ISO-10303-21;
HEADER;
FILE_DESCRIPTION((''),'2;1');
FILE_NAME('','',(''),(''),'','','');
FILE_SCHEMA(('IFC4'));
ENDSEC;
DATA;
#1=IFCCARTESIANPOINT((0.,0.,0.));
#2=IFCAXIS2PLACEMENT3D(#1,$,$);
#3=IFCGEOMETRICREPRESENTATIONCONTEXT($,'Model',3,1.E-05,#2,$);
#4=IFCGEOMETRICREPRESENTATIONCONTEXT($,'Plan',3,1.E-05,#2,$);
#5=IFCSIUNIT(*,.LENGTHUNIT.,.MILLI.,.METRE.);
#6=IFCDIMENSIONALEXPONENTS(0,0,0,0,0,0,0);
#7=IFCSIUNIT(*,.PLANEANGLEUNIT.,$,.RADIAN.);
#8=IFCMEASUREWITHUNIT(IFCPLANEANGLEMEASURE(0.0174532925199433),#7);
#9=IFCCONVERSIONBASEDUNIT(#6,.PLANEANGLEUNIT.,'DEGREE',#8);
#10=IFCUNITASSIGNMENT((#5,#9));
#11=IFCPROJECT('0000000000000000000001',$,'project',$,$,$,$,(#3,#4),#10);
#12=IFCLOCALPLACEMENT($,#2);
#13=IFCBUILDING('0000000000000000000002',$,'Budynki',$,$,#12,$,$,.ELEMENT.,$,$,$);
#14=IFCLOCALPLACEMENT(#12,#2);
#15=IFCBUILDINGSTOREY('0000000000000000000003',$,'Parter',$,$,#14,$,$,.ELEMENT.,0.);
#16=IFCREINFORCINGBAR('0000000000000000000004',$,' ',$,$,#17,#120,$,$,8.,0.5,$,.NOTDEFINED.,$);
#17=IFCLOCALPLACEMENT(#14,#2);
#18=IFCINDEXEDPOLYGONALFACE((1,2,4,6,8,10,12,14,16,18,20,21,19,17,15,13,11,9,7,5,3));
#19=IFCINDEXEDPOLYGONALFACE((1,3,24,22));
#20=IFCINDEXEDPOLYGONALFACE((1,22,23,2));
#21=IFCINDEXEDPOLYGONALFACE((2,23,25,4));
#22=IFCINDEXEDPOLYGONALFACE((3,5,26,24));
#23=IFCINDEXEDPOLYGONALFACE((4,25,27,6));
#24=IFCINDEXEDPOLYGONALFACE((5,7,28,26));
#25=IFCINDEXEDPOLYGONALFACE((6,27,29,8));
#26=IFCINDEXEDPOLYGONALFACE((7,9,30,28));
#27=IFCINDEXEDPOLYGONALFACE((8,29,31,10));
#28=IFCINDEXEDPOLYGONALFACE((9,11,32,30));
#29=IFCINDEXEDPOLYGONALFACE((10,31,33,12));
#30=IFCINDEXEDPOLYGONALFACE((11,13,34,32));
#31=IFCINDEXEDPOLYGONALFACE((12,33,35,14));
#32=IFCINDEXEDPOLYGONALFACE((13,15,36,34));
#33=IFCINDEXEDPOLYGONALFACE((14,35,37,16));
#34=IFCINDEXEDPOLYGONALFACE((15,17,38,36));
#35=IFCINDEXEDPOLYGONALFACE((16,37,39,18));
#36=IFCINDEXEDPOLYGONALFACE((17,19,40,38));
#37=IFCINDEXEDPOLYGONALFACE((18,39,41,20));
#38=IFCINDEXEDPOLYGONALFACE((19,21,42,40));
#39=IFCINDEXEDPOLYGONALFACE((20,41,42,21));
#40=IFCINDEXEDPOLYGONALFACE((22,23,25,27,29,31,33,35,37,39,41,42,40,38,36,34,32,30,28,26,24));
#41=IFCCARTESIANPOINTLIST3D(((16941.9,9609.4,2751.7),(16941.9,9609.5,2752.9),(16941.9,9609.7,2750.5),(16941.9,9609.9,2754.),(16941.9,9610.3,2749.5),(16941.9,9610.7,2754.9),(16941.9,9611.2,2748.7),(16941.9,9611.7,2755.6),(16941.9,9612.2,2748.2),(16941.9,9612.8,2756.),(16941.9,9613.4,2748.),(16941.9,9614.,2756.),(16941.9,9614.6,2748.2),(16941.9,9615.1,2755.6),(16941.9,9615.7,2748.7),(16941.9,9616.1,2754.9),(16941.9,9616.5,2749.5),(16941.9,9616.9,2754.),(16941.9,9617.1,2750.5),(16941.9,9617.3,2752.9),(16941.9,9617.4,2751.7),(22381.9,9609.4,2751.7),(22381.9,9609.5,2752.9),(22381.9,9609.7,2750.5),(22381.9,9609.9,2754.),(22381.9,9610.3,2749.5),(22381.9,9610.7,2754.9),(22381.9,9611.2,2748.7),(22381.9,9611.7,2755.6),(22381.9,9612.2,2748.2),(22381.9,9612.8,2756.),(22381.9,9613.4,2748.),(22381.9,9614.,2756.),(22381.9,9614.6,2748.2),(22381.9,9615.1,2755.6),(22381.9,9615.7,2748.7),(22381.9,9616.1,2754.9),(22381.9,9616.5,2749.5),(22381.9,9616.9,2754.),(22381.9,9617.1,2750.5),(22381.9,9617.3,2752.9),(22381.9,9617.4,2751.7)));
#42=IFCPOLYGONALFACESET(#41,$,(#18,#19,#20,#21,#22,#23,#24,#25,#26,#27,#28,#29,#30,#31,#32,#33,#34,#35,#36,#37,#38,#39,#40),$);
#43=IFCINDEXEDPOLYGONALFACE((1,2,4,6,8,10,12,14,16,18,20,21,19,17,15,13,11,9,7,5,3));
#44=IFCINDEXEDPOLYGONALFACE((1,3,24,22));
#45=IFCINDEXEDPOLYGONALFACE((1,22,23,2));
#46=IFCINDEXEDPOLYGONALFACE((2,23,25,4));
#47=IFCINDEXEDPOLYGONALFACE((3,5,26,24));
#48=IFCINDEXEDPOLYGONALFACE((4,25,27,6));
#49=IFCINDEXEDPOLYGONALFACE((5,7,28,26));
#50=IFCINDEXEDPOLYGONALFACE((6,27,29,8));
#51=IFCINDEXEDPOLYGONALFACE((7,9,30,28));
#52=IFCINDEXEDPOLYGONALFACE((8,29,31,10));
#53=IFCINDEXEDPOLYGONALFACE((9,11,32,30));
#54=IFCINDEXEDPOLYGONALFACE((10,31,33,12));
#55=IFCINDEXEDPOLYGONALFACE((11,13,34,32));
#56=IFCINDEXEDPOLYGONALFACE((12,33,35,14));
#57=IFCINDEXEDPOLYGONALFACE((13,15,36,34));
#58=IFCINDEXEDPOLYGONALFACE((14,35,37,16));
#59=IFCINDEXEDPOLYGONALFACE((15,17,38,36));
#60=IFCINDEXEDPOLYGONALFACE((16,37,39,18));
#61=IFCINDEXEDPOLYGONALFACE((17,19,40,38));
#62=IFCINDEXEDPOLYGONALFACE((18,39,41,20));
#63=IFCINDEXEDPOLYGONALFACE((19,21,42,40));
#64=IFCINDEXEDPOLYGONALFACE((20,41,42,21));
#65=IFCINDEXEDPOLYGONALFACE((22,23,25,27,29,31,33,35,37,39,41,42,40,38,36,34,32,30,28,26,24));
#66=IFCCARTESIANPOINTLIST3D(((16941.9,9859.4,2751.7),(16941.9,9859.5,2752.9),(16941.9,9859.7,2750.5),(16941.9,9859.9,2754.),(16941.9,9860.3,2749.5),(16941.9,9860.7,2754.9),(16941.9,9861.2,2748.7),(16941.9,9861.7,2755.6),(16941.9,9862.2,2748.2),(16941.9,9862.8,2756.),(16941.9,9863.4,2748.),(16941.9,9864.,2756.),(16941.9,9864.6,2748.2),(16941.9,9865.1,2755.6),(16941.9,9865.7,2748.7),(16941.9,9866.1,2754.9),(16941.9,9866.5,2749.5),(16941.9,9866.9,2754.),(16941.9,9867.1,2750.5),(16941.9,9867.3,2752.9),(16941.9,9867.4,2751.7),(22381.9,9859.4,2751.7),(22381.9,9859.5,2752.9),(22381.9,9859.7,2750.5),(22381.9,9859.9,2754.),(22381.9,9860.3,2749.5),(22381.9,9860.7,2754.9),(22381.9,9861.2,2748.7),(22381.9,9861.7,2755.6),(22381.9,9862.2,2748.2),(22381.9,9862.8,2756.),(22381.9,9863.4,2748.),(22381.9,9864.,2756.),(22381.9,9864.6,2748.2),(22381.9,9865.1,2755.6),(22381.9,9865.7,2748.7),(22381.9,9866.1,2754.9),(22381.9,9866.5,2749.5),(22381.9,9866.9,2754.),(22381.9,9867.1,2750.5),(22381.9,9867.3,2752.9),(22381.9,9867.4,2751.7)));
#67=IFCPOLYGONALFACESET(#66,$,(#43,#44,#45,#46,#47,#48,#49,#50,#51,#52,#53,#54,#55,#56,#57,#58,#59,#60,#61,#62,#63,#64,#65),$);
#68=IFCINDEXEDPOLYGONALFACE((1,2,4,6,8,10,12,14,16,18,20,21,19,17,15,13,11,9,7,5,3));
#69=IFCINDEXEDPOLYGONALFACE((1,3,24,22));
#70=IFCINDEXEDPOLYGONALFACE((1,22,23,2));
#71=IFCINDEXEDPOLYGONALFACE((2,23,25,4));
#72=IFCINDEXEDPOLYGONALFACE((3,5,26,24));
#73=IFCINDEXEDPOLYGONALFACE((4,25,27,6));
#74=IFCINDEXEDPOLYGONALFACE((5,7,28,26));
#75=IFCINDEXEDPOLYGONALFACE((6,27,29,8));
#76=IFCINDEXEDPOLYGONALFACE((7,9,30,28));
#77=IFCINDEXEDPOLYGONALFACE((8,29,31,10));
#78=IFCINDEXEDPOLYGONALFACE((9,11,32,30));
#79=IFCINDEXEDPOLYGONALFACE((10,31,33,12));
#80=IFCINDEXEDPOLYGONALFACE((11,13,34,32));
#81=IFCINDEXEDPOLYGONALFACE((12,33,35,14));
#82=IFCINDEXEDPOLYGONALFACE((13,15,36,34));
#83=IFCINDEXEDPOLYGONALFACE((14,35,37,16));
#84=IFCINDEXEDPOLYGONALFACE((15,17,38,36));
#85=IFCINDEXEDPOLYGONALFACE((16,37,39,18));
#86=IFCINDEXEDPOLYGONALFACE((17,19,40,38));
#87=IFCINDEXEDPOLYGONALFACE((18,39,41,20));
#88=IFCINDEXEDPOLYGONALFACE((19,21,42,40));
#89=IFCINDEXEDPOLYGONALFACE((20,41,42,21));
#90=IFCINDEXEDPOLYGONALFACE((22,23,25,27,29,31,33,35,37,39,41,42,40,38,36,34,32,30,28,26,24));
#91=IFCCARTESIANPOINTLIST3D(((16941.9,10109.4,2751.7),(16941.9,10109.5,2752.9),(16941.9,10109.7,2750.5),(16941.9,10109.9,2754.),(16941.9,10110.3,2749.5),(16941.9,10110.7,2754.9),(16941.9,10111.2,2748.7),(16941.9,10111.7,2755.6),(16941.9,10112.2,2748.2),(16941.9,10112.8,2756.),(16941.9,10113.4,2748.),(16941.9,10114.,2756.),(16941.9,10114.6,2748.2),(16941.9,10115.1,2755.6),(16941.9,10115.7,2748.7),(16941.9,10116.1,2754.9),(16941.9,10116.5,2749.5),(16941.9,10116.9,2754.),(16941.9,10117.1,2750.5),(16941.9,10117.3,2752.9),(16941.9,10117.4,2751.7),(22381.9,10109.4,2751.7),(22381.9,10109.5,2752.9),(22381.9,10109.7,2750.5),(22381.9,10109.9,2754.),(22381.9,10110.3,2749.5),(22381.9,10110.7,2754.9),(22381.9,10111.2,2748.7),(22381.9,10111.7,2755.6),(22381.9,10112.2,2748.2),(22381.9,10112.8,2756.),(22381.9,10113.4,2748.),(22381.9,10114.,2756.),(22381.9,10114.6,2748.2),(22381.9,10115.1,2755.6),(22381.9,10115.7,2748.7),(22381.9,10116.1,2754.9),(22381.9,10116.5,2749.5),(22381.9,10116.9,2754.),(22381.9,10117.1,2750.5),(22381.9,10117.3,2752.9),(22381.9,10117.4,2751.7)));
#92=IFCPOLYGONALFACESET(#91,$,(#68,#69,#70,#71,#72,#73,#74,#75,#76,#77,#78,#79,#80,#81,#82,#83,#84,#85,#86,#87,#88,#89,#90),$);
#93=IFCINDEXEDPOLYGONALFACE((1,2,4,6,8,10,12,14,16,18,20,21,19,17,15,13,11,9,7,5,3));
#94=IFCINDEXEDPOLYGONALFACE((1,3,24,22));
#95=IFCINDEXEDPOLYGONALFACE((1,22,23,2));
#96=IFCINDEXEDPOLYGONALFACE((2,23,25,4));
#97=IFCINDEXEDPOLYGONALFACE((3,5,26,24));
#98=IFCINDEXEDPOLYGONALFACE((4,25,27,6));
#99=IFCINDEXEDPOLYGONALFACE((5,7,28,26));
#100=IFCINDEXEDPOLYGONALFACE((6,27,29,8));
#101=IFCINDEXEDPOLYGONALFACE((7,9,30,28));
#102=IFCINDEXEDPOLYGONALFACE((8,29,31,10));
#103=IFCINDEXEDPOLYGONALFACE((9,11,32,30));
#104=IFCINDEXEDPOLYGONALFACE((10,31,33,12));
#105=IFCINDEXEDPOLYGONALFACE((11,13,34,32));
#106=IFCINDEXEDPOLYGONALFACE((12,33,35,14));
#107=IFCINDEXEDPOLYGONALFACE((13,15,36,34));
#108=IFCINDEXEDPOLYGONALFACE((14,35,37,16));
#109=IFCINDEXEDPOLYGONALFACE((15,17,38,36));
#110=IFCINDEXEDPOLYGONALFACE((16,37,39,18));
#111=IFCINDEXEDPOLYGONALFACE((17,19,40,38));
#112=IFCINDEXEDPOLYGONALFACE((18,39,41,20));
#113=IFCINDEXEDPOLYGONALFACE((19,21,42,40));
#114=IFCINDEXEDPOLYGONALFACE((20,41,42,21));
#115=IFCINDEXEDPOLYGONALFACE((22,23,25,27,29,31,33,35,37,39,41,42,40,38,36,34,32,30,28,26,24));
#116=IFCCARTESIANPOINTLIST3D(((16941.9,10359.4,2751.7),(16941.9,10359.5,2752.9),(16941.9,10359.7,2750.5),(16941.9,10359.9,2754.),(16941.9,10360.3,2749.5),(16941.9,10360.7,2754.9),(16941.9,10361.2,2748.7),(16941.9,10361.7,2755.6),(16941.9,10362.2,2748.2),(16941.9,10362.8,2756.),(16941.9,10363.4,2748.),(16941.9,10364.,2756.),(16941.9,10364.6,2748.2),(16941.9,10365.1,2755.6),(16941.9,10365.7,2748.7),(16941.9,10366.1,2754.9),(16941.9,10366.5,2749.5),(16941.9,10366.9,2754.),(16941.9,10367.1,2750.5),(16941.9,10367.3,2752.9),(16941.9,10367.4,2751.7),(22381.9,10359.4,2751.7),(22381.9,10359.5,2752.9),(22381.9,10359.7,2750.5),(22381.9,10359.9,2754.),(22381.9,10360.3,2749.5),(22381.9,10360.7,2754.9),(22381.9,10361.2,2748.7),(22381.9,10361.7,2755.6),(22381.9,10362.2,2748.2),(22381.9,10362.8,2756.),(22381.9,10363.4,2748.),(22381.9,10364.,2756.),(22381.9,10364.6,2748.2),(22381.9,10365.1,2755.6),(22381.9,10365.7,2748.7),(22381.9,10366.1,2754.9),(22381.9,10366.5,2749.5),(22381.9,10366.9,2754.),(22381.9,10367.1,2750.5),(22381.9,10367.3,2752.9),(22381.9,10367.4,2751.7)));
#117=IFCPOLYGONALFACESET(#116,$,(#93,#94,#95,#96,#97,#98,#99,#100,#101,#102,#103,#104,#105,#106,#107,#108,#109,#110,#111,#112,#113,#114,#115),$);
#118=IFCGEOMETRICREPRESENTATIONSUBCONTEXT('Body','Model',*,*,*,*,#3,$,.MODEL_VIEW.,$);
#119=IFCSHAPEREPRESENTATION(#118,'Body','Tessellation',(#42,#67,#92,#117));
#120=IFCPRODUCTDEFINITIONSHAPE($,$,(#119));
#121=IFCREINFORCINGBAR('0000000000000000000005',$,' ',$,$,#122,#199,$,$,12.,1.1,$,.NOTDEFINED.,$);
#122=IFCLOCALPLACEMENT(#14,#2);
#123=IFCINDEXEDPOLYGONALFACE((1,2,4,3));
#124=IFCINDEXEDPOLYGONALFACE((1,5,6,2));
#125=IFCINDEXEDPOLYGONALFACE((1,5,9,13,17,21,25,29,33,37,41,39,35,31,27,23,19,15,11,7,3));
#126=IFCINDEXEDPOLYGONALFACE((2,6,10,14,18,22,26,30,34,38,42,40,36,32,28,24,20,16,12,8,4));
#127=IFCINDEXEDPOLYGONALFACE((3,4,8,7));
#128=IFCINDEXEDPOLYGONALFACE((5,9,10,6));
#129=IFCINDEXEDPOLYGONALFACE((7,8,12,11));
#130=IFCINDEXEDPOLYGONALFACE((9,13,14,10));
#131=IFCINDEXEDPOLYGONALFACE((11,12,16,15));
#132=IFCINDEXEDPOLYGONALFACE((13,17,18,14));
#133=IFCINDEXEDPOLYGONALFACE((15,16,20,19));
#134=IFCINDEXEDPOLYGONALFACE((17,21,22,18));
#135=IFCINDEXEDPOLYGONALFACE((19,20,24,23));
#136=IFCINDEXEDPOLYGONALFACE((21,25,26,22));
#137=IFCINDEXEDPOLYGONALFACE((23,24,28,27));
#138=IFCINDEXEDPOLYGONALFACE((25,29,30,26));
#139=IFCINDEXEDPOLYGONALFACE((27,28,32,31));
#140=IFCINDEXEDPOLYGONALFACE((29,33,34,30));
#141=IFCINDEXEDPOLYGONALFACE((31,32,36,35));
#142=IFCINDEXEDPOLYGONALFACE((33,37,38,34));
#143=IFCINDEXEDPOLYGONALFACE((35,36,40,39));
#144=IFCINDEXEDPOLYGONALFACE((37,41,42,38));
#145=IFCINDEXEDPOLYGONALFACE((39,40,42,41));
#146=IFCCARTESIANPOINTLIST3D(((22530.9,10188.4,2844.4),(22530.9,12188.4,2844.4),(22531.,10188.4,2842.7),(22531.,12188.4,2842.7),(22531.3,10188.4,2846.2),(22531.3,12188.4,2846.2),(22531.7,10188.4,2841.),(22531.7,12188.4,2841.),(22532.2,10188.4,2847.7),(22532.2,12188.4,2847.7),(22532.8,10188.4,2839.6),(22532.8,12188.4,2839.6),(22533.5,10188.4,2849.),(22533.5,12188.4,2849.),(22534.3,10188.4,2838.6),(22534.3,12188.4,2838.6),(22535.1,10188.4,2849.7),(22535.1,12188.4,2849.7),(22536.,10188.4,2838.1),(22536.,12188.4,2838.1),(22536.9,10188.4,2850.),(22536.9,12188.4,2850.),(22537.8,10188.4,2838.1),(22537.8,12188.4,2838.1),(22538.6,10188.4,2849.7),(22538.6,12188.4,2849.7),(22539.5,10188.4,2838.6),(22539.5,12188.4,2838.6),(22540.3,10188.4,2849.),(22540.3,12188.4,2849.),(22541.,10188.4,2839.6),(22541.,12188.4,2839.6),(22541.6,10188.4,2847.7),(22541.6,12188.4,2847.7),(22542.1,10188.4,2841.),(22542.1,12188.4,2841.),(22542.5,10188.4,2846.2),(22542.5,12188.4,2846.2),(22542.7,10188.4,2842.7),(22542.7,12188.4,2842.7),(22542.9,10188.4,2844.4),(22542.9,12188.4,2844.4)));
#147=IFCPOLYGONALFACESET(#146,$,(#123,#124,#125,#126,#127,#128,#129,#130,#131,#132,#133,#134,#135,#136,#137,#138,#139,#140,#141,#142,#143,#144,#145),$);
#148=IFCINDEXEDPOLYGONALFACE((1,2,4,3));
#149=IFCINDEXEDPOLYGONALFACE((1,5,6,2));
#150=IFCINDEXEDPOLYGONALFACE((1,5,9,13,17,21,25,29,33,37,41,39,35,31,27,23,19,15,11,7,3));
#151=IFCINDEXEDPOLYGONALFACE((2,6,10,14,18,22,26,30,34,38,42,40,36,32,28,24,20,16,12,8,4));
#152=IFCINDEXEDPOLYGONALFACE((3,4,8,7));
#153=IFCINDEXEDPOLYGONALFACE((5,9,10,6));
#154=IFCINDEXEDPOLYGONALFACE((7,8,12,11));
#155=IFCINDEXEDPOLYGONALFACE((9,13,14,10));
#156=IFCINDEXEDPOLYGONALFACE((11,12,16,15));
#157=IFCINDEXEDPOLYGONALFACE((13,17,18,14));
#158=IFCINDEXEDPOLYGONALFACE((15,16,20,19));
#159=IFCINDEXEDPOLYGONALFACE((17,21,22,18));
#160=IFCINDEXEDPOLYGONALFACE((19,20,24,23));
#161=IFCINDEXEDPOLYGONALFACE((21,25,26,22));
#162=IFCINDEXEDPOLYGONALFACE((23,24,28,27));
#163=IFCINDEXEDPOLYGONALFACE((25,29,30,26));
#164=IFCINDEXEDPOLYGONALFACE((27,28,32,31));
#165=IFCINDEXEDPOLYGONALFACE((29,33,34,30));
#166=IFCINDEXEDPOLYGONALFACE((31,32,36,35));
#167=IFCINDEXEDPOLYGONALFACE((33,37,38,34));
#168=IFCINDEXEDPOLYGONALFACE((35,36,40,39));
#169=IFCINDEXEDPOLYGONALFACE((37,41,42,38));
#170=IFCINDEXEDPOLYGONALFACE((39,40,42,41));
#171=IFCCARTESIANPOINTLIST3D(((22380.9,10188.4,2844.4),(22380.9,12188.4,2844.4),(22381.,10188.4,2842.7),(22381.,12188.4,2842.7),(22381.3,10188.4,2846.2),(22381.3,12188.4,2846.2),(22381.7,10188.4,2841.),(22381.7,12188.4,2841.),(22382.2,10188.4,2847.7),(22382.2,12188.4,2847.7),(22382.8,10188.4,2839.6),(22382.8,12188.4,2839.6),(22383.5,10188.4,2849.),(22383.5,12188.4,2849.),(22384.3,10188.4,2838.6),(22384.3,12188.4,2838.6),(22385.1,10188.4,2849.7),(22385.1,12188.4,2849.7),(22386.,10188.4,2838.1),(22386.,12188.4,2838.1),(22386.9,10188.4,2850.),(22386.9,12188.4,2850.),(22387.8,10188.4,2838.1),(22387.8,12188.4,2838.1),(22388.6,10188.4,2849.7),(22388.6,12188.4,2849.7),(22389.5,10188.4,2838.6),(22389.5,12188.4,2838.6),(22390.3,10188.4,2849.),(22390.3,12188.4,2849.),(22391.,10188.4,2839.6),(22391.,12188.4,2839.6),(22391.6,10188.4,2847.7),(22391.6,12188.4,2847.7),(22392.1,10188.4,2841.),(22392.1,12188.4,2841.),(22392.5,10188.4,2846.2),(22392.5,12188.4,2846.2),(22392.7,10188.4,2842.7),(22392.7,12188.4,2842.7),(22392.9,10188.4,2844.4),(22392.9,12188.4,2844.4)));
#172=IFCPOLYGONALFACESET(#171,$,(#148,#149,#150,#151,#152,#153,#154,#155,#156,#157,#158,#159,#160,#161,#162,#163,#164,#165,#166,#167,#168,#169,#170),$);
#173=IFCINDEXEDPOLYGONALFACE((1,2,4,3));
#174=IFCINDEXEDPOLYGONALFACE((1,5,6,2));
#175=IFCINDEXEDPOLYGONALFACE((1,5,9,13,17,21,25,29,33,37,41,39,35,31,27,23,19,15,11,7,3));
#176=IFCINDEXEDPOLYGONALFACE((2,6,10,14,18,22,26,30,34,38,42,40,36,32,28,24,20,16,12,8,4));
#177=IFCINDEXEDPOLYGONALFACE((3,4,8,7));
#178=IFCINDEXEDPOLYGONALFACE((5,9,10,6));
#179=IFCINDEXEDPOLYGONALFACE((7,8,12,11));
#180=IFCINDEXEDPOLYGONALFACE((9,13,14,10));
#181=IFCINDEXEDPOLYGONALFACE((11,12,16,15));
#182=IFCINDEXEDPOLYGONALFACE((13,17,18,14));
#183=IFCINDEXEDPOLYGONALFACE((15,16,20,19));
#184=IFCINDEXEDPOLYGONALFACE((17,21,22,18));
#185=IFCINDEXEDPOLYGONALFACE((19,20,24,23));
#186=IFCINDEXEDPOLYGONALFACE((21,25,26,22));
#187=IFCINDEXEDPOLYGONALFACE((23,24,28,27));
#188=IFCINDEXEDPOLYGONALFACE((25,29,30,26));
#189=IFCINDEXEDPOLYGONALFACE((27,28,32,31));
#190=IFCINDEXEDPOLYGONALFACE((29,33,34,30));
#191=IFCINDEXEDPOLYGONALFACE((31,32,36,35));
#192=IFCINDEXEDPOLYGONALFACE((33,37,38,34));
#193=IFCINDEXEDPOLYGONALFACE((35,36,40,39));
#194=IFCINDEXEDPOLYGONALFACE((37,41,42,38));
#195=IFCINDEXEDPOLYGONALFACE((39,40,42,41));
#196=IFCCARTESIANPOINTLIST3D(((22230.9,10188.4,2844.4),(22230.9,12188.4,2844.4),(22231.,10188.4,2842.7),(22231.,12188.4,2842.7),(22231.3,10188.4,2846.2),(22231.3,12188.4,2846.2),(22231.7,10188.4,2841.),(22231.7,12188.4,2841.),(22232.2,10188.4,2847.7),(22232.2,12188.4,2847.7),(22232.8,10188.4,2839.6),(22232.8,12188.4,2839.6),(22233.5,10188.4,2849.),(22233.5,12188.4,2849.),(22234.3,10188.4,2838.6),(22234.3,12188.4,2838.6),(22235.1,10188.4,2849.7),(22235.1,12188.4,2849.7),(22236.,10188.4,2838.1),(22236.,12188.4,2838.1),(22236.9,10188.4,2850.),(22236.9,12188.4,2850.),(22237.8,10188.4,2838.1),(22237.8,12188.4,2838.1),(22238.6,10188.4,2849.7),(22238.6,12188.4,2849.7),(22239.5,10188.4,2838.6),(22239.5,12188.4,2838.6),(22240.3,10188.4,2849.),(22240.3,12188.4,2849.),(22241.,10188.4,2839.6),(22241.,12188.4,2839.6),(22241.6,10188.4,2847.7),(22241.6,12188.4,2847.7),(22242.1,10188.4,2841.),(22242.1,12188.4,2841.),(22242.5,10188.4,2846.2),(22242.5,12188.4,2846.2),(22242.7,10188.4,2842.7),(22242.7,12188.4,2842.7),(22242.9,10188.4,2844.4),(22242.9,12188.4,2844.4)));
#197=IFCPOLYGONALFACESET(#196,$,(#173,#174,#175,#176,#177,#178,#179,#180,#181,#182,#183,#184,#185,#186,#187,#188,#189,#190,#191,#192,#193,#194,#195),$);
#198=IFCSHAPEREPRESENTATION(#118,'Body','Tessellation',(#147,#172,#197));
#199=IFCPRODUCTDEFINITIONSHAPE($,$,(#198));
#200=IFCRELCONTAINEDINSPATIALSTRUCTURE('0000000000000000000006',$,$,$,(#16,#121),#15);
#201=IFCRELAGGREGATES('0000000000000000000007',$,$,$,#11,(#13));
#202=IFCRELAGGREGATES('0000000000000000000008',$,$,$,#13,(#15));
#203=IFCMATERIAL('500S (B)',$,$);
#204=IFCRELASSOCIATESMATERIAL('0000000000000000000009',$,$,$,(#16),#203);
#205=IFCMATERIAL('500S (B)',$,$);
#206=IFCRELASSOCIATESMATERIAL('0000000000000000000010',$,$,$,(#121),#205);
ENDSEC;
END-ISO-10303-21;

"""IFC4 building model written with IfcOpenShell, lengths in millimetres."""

from ifc_helpers import new_model, entity, si_unit, converted_unit, frame, origin, place, context, subcontext, project, spatial, material, element, save


model = new_model("IFC4")

# Units and contexts
model_context = context("Model", 3, precision=1e-05, world=origin())
plan_context = context("Plan", 3, precision=1e-05, world=origin())
body_context = subcontext(model_context, "Body", "Model", "MODEL_VIEW")
ifc_project = project(units=[si_unit("LENGTHUNIT", "METRE", prefix="MILLI"), converted_unit("PLANEANGLEUNIT", "DEGREE", entity("IfcPlaneAngleMeasure", 0.0174532925199433), si_unit("PLANEANGLEUNIT", "RADIAN"), dimensions=[0, 0, 0, 0, 0, 0, 0])], contexts=[model_context, plan_context])

# Building, storey
building_placement = place(None, origin())
building = spatial("IfcBuilding", under=ifc_project, at=building_placement, Name="Budynki", CompositionType="ELEMENT")
storey_placement = place(building_placement, origin())
storey = spatial("IfcBuildingStorey", under=building, at=storey_placement, Name="Parter", CompositionType="ELEMENT", Elevation=0.0)

# Reinforcing bars
ifc_material_1 = material(Name="500S (B)")
reinforcing_bar_1_placement = place(storey_placement, frame((22381.9, 9613.4, 2752.0)))
element("IfcReinforcingBar", 1, at=reinforcing_bar_1_placement, inside=storey, material=ifc_material_1, Name=" ", CrossSectionArea=0.5, NominalDiameter=8.0, PredefinedType="NOTDEFINED", context=body_context, shape_type="AdvancedSweptSolid", body=[
    entity("IfcSweptDiskSolid", entity("IfcPolyline", [entity("IfcCartesianPoint", [0.0, 0.0, 0.0]), entity("IfcCartesianPoint", [-5440.0, 0.0, 0.0])]), 4.0, None, 0.0, 1.0),
    entity("IfcSweptDiskSolid", entity("IfcPolyline", [entity("IfcCartesianPoint", [0.0, 250.0, 0.0]), entity("IfcCartesianPoint", [-5440.0, 250.0, 0.0])]), 4.0, None, 0.0, 1.0),
    entity("IfcSweptDiskSolid", entity("IfcPolyline", [entity("IfcCartesianPoint", [0.0, 500.0, 0.0]), entity("IfcCartesianPoint", [-5440.0, 500.0, 0.0])]), 4.0, None, 0.0, 1.0),
    entity("IfcSweptDiskSolid", entity("IfcPolyline", [entity("IfcCartesianPoint", [0.0, 750.0, 0.0]), entity("IfcCartesianPoint", [-5440.0, 750.0, 0.0])]), 4.0, None, 0.0, 1.0),
])
ifc_material_2 = material(Name="500S (B)")
reinforcing_bar_2_placement = place(storey_placement, frame((22536.9, 10188.4, 2844.0)))
element("IfcReinforcingBar", 2, at=reinforcing_bar_2_placement, inside=storey, material=ifc_material_2, Name=" ", CrossSectionArea=1.1, NominalDiameter=12.0, PredefinedType="NOTDEFINED", context=body_context, shape_type="AdvancedSweptSolid", body=[
    entity("IfcSweptDiskSolid", entity("IfcPolyline", [entity("IfcCartesianPoint", [0.0, 0.0, 0.0]), entity("IfcCartesianPoint", [0.0, 2000.0, 0.0])]), 6.0, None, 0.0, 1.0),
    entity("IfcSweptDiskSolid", entity("IfcPolyline", [entity("IfcCartesianPoint", [-150.0, 0.0, 0.0]), entity("IfcCartesianPoint", [-150.0, 2000.0, 0.0])]), 6.0, None, 0.0, 1.0),
    entity("IfcSweptDiskSolid", entity("IfcPolyline", [entity("IfcCartesianPoint", [-300.0, 0.0, 0.0]), entity("IfcCartesianPoint", [-300.0, 2000.0, 0.0])]), 6.0, None, 0.0, 1.0),
])

save(model, "model.ifc")
